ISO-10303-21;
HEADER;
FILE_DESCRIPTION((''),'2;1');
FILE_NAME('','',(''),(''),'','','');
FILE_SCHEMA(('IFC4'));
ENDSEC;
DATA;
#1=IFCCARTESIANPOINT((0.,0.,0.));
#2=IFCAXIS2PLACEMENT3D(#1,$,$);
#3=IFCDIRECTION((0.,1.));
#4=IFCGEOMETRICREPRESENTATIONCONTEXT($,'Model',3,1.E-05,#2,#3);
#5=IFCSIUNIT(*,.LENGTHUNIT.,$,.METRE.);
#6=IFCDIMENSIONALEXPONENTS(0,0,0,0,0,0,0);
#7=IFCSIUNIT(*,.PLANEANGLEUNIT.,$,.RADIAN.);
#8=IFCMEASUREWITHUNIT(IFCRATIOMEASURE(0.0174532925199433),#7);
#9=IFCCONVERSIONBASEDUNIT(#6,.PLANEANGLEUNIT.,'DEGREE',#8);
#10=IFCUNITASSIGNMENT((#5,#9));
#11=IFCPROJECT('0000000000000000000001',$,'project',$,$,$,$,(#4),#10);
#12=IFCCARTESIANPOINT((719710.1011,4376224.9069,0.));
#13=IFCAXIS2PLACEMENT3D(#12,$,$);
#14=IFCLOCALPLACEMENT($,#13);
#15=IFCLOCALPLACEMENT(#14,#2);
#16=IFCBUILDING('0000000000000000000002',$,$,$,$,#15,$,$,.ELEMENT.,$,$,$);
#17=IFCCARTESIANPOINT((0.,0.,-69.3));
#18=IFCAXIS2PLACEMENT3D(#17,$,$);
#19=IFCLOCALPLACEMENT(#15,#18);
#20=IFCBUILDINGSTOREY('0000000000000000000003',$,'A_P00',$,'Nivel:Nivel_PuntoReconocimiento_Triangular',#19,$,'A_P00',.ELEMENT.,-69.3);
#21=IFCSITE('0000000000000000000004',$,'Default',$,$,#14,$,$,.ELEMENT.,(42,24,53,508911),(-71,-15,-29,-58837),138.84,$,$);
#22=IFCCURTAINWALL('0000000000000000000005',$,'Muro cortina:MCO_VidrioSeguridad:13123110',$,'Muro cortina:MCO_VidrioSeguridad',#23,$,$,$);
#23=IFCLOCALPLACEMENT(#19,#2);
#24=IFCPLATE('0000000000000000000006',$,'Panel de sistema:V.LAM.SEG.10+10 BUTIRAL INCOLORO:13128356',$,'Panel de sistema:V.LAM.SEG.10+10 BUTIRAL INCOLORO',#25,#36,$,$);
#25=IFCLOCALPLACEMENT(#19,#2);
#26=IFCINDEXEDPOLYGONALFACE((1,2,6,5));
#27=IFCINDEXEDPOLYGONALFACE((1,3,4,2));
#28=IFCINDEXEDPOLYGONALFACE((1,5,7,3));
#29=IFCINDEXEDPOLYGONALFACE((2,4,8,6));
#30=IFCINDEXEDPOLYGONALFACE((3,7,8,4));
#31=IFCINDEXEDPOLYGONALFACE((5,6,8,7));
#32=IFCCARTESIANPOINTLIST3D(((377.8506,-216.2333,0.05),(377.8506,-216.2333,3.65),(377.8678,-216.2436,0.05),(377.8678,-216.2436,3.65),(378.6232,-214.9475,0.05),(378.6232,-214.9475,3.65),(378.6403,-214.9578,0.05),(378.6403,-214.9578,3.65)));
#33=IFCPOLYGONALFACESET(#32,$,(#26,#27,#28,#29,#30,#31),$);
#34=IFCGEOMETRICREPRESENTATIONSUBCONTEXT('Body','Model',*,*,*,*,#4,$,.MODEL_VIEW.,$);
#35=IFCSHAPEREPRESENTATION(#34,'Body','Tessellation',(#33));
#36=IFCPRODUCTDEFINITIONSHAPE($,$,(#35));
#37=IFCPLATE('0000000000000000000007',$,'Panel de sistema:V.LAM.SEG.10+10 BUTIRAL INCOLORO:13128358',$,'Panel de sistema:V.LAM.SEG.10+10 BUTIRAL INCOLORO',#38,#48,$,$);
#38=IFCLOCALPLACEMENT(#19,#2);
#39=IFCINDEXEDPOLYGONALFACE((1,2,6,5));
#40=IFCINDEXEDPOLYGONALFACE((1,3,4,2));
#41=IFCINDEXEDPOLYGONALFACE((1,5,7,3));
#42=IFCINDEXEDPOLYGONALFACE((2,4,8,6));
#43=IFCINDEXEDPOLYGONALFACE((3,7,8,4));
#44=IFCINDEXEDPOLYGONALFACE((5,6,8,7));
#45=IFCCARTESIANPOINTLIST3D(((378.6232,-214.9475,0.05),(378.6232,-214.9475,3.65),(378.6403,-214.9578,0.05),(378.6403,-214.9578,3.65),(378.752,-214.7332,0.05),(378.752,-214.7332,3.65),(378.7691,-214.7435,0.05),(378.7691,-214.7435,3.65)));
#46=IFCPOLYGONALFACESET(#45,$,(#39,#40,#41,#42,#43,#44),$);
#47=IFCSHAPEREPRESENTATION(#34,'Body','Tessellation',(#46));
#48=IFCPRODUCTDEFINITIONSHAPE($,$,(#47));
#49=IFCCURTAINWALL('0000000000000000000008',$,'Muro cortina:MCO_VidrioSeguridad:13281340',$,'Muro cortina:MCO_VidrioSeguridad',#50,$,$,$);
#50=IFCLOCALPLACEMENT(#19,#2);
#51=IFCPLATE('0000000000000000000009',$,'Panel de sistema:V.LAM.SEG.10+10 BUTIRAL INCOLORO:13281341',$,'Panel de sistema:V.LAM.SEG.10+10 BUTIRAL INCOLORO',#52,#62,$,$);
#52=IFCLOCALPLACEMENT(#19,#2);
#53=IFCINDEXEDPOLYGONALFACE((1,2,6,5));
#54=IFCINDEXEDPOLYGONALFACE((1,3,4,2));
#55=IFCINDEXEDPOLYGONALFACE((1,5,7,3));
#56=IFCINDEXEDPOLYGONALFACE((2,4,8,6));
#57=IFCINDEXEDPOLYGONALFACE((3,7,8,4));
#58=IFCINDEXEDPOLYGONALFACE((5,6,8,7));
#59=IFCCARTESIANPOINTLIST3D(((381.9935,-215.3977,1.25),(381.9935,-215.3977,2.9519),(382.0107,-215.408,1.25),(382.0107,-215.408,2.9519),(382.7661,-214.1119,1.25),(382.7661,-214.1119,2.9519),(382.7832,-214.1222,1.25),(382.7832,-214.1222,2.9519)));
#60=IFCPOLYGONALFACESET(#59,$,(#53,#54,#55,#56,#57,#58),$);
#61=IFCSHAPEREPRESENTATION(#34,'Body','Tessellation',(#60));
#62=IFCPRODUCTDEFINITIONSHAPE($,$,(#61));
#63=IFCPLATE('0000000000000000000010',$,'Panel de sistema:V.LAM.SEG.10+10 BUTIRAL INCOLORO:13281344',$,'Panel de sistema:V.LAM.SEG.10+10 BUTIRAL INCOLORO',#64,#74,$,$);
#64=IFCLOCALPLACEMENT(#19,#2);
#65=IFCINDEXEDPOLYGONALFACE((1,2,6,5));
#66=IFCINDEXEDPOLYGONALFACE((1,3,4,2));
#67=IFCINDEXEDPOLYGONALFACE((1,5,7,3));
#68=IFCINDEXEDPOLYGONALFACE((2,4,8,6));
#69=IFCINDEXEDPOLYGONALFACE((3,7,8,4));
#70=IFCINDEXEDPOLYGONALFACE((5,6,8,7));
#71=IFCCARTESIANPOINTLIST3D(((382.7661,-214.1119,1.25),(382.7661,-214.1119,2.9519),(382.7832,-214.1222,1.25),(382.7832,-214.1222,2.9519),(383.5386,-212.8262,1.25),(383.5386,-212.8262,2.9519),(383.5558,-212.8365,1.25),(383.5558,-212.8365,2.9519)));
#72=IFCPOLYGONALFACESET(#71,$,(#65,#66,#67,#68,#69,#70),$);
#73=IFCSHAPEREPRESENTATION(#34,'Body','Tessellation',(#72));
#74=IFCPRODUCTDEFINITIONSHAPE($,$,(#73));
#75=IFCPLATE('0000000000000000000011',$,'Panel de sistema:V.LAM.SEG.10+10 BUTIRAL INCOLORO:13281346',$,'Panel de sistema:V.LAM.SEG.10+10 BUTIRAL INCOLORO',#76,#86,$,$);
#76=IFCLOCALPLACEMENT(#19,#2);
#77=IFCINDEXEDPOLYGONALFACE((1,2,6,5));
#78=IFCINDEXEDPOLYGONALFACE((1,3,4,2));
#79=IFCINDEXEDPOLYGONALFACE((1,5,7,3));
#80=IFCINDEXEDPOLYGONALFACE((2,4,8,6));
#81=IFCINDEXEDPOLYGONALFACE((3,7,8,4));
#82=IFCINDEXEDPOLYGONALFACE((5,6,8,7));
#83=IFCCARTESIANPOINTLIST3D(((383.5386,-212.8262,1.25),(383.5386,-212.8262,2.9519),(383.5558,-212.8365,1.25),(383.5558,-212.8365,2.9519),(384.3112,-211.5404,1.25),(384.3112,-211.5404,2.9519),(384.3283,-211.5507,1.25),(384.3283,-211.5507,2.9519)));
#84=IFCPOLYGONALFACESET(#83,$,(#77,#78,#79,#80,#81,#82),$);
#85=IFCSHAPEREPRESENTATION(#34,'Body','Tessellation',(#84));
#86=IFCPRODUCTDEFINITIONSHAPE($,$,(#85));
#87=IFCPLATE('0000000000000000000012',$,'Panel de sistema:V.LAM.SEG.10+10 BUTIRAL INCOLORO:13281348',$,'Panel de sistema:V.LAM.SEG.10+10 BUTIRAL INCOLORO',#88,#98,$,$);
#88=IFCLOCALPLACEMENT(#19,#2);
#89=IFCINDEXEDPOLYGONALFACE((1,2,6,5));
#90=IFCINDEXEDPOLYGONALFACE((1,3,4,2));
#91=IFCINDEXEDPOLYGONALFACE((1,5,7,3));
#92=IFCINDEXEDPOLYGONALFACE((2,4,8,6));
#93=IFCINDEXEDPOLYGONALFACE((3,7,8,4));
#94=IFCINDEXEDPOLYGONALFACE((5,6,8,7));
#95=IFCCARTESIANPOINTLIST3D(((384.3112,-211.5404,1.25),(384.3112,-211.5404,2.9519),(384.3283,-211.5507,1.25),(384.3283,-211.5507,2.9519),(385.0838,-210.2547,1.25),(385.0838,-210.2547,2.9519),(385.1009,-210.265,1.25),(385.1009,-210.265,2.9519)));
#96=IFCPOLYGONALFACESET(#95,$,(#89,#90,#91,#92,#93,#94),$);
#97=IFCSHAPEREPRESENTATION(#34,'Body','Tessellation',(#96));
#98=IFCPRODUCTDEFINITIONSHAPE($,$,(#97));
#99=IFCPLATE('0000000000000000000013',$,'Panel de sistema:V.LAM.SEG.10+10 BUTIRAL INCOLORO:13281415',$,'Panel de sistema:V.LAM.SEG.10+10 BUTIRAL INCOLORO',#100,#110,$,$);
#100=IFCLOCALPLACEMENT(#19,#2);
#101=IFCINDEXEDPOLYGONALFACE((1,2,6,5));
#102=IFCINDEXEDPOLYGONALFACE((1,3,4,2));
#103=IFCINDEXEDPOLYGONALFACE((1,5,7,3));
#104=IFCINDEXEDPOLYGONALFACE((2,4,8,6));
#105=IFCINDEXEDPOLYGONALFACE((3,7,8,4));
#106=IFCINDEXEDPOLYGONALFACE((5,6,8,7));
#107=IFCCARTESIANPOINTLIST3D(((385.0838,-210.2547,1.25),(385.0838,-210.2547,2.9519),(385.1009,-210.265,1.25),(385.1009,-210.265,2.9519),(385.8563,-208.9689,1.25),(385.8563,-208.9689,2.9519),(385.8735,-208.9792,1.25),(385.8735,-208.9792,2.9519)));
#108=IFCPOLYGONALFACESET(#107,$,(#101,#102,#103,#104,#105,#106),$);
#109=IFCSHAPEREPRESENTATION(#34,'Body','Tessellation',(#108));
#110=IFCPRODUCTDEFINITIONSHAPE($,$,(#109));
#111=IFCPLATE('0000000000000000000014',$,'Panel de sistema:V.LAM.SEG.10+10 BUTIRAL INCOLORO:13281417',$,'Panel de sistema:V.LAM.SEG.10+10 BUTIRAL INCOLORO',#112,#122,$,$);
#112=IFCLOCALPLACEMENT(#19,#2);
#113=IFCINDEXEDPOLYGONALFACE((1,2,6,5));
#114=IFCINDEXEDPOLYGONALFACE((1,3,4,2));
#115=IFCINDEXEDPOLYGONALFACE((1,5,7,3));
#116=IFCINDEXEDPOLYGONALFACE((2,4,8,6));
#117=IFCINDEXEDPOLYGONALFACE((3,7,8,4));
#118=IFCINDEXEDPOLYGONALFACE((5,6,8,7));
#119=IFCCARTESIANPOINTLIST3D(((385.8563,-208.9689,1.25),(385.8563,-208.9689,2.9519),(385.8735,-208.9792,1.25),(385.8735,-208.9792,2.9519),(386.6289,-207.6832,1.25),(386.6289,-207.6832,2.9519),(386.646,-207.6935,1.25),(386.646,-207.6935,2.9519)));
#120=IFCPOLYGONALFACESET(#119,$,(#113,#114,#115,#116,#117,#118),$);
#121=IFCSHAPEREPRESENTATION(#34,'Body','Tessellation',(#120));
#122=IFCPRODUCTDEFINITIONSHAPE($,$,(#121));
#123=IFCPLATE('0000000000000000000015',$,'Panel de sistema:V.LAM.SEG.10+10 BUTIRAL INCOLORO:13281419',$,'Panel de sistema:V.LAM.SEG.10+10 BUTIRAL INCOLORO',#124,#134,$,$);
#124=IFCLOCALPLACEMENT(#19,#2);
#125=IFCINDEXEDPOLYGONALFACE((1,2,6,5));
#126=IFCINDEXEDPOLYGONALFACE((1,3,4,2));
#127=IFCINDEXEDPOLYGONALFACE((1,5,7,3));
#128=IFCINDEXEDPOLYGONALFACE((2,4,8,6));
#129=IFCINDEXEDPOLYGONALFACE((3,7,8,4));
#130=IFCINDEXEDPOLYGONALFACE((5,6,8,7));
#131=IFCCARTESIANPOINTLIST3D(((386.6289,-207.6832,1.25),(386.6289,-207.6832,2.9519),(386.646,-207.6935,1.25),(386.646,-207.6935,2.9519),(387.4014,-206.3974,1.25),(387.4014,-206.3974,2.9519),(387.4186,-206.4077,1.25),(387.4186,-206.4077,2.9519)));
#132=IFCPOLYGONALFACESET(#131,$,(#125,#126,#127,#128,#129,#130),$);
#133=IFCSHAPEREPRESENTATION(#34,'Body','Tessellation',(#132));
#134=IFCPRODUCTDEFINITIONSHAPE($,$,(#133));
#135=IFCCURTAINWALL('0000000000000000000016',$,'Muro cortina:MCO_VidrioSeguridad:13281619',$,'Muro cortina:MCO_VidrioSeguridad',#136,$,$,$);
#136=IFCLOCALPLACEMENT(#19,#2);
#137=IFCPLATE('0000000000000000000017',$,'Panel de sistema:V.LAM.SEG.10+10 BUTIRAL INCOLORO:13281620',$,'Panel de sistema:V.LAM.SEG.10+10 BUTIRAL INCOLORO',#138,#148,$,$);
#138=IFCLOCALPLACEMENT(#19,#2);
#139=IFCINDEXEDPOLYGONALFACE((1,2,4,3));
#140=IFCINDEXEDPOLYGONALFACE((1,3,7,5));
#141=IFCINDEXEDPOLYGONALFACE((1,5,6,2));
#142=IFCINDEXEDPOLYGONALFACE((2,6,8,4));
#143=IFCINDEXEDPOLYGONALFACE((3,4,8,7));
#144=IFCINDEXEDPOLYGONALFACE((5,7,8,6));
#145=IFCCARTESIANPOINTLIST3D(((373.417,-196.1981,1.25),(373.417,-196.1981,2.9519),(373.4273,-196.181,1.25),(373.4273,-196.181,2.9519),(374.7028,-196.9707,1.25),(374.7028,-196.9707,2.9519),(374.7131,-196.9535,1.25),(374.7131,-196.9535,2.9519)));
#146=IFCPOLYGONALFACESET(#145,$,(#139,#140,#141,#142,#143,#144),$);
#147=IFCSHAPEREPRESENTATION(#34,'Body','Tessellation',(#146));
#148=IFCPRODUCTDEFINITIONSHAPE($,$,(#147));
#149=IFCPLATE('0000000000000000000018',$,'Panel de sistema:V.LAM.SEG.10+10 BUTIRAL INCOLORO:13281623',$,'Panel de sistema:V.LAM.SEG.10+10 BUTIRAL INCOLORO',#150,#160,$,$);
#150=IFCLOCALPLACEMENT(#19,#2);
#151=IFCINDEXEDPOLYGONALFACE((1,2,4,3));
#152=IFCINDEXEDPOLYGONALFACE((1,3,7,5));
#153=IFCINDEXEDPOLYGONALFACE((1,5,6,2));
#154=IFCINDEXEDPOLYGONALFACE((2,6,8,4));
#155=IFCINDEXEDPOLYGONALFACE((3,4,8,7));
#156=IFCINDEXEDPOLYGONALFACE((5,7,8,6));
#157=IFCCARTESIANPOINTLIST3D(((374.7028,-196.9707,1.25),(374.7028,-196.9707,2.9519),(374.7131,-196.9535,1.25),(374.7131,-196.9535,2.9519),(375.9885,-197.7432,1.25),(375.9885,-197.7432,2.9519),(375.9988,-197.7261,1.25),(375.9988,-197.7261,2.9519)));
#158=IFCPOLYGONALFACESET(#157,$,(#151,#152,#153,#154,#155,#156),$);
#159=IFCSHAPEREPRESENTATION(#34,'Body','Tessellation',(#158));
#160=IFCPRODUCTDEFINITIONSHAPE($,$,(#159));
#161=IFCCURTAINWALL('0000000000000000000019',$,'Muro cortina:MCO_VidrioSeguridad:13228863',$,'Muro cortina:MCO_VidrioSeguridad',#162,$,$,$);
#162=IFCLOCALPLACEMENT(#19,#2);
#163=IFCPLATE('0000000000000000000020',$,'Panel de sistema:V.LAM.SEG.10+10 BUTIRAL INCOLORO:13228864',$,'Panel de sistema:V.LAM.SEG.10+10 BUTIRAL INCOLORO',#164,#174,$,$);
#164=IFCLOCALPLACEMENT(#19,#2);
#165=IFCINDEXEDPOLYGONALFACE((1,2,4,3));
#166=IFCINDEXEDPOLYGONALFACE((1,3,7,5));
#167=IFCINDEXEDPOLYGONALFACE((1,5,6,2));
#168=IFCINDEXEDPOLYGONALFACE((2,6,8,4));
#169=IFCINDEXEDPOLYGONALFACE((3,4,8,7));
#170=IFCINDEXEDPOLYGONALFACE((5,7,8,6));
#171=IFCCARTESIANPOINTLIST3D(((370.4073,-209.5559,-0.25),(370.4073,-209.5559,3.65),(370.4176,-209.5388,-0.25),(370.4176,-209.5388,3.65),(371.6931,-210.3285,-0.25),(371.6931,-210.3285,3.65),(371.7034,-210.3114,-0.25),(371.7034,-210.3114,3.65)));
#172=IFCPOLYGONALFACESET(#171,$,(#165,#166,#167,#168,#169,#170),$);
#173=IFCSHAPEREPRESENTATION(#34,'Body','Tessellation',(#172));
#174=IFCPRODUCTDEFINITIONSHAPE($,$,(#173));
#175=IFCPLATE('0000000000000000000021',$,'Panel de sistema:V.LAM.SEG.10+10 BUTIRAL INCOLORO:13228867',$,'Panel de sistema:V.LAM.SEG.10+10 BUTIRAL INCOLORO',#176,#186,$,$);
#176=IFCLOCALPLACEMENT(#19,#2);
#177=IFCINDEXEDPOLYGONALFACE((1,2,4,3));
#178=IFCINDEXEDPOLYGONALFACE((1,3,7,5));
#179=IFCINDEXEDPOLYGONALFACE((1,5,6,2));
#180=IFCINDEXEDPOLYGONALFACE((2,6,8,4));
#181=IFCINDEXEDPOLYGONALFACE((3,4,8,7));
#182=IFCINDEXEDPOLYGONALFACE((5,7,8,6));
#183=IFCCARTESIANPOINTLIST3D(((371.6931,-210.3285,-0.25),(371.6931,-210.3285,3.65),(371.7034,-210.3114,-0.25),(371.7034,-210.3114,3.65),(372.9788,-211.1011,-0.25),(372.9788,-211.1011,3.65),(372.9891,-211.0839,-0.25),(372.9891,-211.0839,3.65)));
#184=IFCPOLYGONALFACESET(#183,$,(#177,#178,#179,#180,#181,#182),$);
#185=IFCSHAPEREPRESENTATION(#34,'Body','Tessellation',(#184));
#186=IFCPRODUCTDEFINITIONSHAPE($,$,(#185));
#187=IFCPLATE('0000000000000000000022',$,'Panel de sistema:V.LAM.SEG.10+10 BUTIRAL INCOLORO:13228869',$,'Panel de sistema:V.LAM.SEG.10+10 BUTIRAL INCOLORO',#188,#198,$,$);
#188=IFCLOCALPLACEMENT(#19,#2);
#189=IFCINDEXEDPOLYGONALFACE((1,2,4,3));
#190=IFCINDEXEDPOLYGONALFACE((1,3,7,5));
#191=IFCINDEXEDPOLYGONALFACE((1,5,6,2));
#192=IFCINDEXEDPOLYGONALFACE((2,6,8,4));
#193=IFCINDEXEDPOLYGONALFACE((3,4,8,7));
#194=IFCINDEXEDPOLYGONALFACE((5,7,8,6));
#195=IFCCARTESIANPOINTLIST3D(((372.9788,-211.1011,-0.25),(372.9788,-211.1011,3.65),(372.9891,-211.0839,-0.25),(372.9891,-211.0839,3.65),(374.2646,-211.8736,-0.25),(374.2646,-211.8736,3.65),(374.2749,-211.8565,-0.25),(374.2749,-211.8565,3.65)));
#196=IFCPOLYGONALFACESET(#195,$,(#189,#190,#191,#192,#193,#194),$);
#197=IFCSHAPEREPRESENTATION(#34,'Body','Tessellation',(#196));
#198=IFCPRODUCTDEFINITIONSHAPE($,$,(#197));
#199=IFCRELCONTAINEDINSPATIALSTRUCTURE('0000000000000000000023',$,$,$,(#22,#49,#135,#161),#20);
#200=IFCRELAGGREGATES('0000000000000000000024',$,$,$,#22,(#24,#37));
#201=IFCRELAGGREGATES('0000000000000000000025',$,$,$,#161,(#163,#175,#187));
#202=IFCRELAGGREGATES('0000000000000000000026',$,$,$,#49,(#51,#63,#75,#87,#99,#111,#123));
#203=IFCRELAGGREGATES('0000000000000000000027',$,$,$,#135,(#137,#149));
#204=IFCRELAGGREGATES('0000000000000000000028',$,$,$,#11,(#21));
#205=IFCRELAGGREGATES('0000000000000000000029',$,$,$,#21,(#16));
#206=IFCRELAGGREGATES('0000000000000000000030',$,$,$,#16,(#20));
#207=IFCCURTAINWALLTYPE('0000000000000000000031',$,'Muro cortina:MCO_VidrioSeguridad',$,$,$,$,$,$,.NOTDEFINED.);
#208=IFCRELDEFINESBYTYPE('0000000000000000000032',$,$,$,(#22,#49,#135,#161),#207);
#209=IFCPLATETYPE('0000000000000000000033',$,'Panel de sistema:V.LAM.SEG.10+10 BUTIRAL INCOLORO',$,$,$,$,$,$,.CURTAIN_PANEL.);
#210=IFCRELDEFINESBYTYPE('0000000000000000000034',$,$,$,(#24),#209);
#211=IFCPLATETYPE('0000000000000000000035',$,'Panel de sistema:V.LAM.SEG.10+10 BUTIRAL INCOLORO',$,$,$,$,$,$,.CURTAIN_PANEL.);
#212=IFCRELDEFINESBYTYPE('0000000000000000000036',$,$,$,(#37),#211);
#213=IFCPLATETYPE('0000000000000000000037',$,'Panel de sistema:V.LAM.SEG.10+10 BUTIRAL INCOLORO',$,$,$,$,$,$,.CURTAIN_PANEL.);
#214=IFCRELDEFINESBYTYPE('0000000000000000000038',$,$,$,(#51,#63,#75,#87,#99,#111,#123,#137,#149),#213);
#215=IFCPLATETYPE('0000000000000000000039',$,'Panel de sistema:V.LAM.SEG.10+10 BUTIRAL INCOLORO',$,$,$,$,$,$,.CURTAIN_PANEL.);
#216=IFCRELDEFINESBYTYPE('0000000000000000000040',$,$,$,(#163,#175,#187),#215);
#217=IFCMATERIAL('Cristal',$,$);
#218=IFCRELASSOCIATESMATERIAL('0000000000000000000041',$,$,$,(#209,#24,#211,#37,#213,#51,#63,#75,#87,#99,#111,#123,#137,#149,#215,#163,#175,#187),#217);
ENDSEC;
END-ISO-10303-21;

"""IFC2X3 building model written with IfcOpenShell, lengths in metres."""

from ifc_helpers import new_model, entity, si_unit, converted_unit, direction, frame, frame_2d, origin, origin_2d_with_axis, place, context, subcontext, project, spatial, rectangle, extrude, source, transform, mapped, material, type_object, type_shapes, element, aggregate, save


model = new_model("IFC2X3")

# Units and contexts
model_context = context("Model", 3, precision=1e-05, world=origin(), true_north=direction((0.0, 1.0)))
body_context = subcontext(model_context, "Body", "Model", "MODEL_VIEW")
ifc_project = project(units=[si_unit("LENGTHUNIT", "METRE"), converted_unit("PLANEANGLEUNIT", "DEGREE", entity("IfcRatioMeasure", 0.0174532925199433), si_unit("PLANEANGLEUNIT", "RADIAN"), dimensions=[0, 0, 0, 0, 0, 0, 0])], contexts=[model_context])

# Site, building, storey
site_placement = place(None, frame((719710.1011, 4376224.9069, 0.0)))
site = spatial("IfcSite", under=ifc_project, at=site_placement, Name="Default", CompositionType="ELEMENT", RefLatitude=(42, 24, 53, 508911), RefLongitude=(-71, -15, -29, -58837), RefElevation=138.84)
building_placement = place(site_placement, origin())
building = spatial("IfcBuilding", under=site, at=building_placement, CompositionType="ELEMENT")
storey_placement = place(building_placement, frame((0.0, 0.0, -69.3)))
storey = spatial("IfcBuildingStorey", under=building, at=storey_placement, Name="A_P00", ObjectType="Nivel:Nivel_PuntoReconocimiento_Triangular", LongName="A_P00", CompositionType="ELEMENT", Elevation=-69.3)

# Curtain walls, plates
curtain_wall_type = type_object("IfcCurtainWallType", Name="Muro cortina:MCO_VidrioSeguridad", PredefinedType="NOTDEFINED")
curtain_wall_1_placement = place(storey_placement, frame((0.0, 0.0, 69.3)))
curtain_wall_1 = element("IfcCurtainWall", 1, at=curtain_wall_1_placement, inside=storey, type_object=curtain_wall_type, Name="Muro cortina:MCO_VidrioSeguridad:13123110", ObjectType="Muro cortina:MCO_VidrioSeguridad")
ifc_material_1 = material(Name="Cristal")
plate_type_1 = type_object("IfcPlateType", Name="Panel de sistema:V.LAM.SEG.10+10 BUTIRAL INCOLORO", PredefinedType="CURTAIN_PANEL", material=ifc_material_1)
shared_shape_1 = source(origin(), body_context, "Body", "SweptSolid", [
    extrude(rectangle(XDim=0.02, YDim=1.5, at=frame_2d((0.0, 0.0), x_axis=(1.0, 0.0))), frame((0.0, 0.0, 0.0), z_axis=(0.0, 0.0, 1.0), x_axis=(0.0, 1.0, 0.0)), (0.0, 0.0, 1.0), 3.6),
])
type_shapes(plate_type_1, [shared_shape_1])
plate_1_placement = place(curtain_wall_1_placement, frame((378.2455, -215.5955, -69.25), z_axis=(0.0, 0.0, 1.0), x_axis=(0.515038, 0.857167, 0.0)))
plate_1 = element("IfcPlate", 2, at=plate_1_placement, type_object=plate_type_1, material=ifc_material_1, Name="Panel de sistema:V.LAM.SEG.10+10 BUTIRAL INCOLORO:13128356", ObjectType="Panel de sistema:V.LAM.SEG.10+10 BUTIRAL INCOLORO", context=body_context, shape_type="MappedRepresentation", body=[
    mapped(shared_shape_1, transform((0.0, 0.0, 0.0), scale=1.0)),
])
plate_type_2 = type_object("IfcPlateType", Name="Panel de sistema:V.LAM.SEG.10+10 BUTIRAL INCOLORO", PredefinedType="CURTAIN_PANEL", material=ifc_material_1)
shared_shape_2 = source(origin(), body_context, "Body", "SweptSolid", [
    extrude(rectangle(XDim=0.02, YDim=0.25, at=origin_2d_with_axis()), frame((0.0, 0.0, 0.0), z_axis=(0.0, 0.0, 1.0), x_axis=(0.0, 1.0, 0.0)), (0.0, 0.0, 1.0), 3.6),
])
type_shapes(plate_type_2, [shared_shape_2])
plate_2_placement = place(curtain_wall_1_placement, frame((378.6962, -214.8455, -69.25), z_axis=(0.0, 0.0, 1.0), x_axis=(0.515038, 0.857167, 0.0)))
plate_2 = element("IfcPlate", 3, at=plate_2_placement, type_object=plate_type_2, material=ifc_material_1, Name="Panel de sistema:V.LAM.SEG.10+10 BUTIRAL INCOLORO:13128358", ObjectType="Panel de sistema:V.LAM.SEG.10+10 BUTIRAL INCOLORO", context=body_context, shape_type="MappedRepresentation", body=[
    mapped(shared_shape_2, transform((0.0, 0.0, 0.0), scale=1.0)),
])
aggregate(curtain_wall_1, [plate_1, plate_2])
curtain_wall_2_placement = place(storey_placement, frame((0.0, 0.0, 69.3)))
curtain_wall_2 = element("IfcCurtainWall", 4, at=curtain_wall_2_placement, inside=storey, type_object=curtain_wall_type, Name="Muro cortina:MCO_VidrioSeguridad:13281340", ObjectType="Muro cortina:MCO_VidrioSeguridad")
plate_type_3 = type_object("IfcPlateType", Name="Panel de sistema:V.LAM.SEG.10+10 BUTIRAL INCOLORO", PredefinedType="CURTAIN_PANEL", material=ifc_material_1)
shared_shape_3 = source(origin(), body_context, "Body", "SweptSolid", [
    extrude(rectangle(XDim=0.02, YDim=1.5, at=frame_2d((0.0, 0.0), x_axis=(1.0, 0.0))), frame((0.0, 0.0, 0.0), z_axis=(0.0, 0.0, 1.0), x_axis=(0.0, 1.0, 0.0)), (0.0, 0.0, 1.0), 1.7019),
])
type_shapes(plate_type_3, [shared_shape_3])
plate_3_placement = place(curtain_wall_2_placement, frame((382.3884, -214.7599, -68.05), z_axis=(0.0, 0.0, 1.0), x_axis=(0.515038, 0.857167, 0.0)))
plate_3 = element("IfcPlate", 5, at=plate_3_placement, type_object=plate_type_3, material=ifc_material_1, Name="Panel de sistema:V.LAM.SEG.10+10 BUTIRAL INCOLORO:13281341", ObjectType="Panel de sistema:V.LAM.SEG.10+10 BUTIRAL INCOLORO", context=body_context, shape_type="MappedRepresentation", body=[
    mapped(shared_shape_3, transform((0.0, 0.0, 0.0), scale=1.0)),
])
plate_4_placement = place(curtain_wall_2_placement, frame((383.1609, -213.4742, -68.05), z_axis=(0.0, 0.0, 1.0), x_axis=(0.515038, 0.857167, 0.0)))
plate_4 = element("IfcPlate", 6, at=plate_4_placement, type_object=plate_type_3, material=ifc_material_1, Name="Panel de sistema:V.LAM.SEG.10+10 BUTIRAL INCOLORO:13281344", ObjectType="Panel de sistema:V.LAM.SEG.10+10 BUTIRAL INCOLORO", context=body_context, shape_type="MappedRepresentation", body=[
    mapped(shared_shape_3, transform((0.0, 0.0, 0.0), scale=1.0)),
])
plate_5_placement = place(curtain_wall_2_placement, frame((383.9335, -212.1884, -68.05), z_axis=(0.0, 0.0, 1.0), x_axis=(0.515038, 0.857167, 0.0)))
plate_5 = element("IfcPlate", 7, at=plate_5_placement, type_object=plate_type_3, material=ifc_material_1, Name="Panel de sistema:V.LAM.SEG.10+10 BUTIRAL INCOLORO:13281346", ObjectType="Panel de sistema:V.LAM.SEG.10+10 BUTIRAL INCOLORO", context=body_context, shape_type="MappedRepresentation", body=[
    mapped(shared_shape_3, transform((0.0, 0.0, 0.0), scale=1.0)),
])
plate_6_placement = place(curtain_wall_2_placement, frame((384.706, -210.9027, -68.05), z_axis=(0.0, 0.0, 1.0), x_axis=(0.515038, 0.857167, 0.0)))
plate_6 = element("IfcPlate", 8, at=plate_6_placement, type_object=plate_type_3, material=ifc_material_1, Name="Panel de sistema:V.LAM.SEG.10+10 BUTIRAL INCOLORO:13281348", ObjectType="Panel de sistema:V.LAM.SEG.10+10 BUTIRAL INCOLORO", context=body_context, shape_type="MappedRepresentation", body=[
    mapped(shared_shape_3, transform((0.0, 0.0, 0.0), scale=1.0)),
])
plate_7_placement = place(curtain_wall_2_placement, frame((385.4786, -209.6169, -68.05), z_axis=(0.0, 0.0, 1.0), x_axis=(0.515038, 0.857167, 0.0)))
plate_7 = element("IfcPlate", 9, at=plate_7_placement, type_object=plate_type_3, material=ifc_material_1, Name="Panel de sistema:V.LAM.SEG.10+10 BUTIRAL INCOLORO:13281415", ObjectType="Panel de sistema:V.LAM.SEG.10+10 BUTIRAL INCOLORO", context=body_context, shape_type="MappedRepresentation", body=[
    mapped(shared_shape_3, transform((0.0, 0.0, 0.0), scale=1.0)),
])
plate_8_placement = place(curtain_wall_2_placement, frame((386.2512, -208.3312, -68.05), z_axis=(0.0, 0.0, 1.0), x_axis=(0.515038, 0.857167, 0.0)))
plate_8 = element("IfcPlate", 10, at=plate_8_placement, type_object=plate_type_3, material=ifc_material_1, Name="Panel de sistema:V.LAM.SEG.10+10 BUTIRAL INCOLORO:13281417", ObjectType="Panel de sistema:V.LAM.SEG.10+10 BUTIRAL INCOLORO", context=body_context, shape_type="MappedRepresentation", body=[
    mapped(shared_shape_3, transform((0.0, 0.0, 0.0), scale=1.0)),
])
plate_9_placement = place(curtain_wall_2_placement, frame((387.0237, -207.0454, -68.05), z_axis=(0.0, 0.0, 1.0), x_axis=(0.515038, 0.857167, 0.0)))
plate_9 = element("IfcPlate", 11, at=plate_9_placement, type_object=plate_type_3, material=ifc_material_1, Name="Panel de sistema:V.LAM.SEG.10+10 BUTIRAL INCOLORO:13281419", ObjectType="Panel de sistema:V.LAM.SEG.10+10 BUTIRAL INCOLORO", context=body_context, shape_type="MappedRepresentation", body=[
    mapped(shared_shape_3, transform((0.0, 0.0, 0.0), scale=1.0)),
])
curtain_wall_3_placement = place(storey_placement, frame((0.0, 0.0, 69.3)))
curtain_wall_3 = element("IfcCurtainWall", 12, at=curtain_wall_3_placement, inside=storey, type_object=curtain_wall_type, Name="Muro cortina:MCO_VidrioSeguridad:13281619", ObjectType="Muro cortina:MCO_VidrioSeguridad")
plate_10_placement = place(curtain_wall_3_placement, frame((374.065, -196.5758, -68.05), z_axis=(0.0, 0.0, 1.0), x_axis=(0.857167, -0.515038, 0.0)))
plate_10 = element("IfcPlate", 13, at=plate_10_placement, type_object=plate_type_3, material=ifc_material_1, Name="Panel de sistema:V.LAM.SEG.10+10 BUTIRAL INCOLORO:13281620", ObjectType="Panel de sistema:V.LAM.SEG.10+10 BUTIRAL INCOLORO", context=body_context, shape_type="MappedRepresentation", body=[
    mapped(shared_shape_3, transform((0.0, 0.0, 0.0), scale=1.0)),
])
plate_11_placement = place(curtain_wall_3_placement, frame((375.3508, -197.3484, -68.05), z_axis=(0.0, 0.0, 1.0), x_axis=(0.857167, -0.515038, 0.0)))
plate_11 = element("IfcPlate", 14, at=plate_11_placement, type_object=plate_type_3, material=ifc_material_1, Name="Panel de sistema:V.LAM.SEG.10+10 BUTIRAL INCOLORO:13281623", ObjectType="Panel de sistema:V.LAM.SEG.10+10 BUTIRAL INCOLORO", context=body_context, shape_type="MappedRepresentation", body=[
    mapped(shared_shape_3, transform((0.0, 0.0, 0.0), scale=1.0)),
])
curtain_wall_4_placement = place(storey_placement, frame((0.0, 0.0, 69.3)))
curtain_wall_4 = element("IfcCurtainWall", 15, at=curtain_wall_4_placement, inside=storey, type_object=curtain_wall_type, Name="Muro cortina:MCO_VidrioSeguridad:13228863", ObjectType="Muro cortina:MCO_VidrioSeguridad")
plate_type_4 = type_object("IfcPlateType", Name="Panel de sistema:V.LAM.SEG.10+10 BUTIRAL INCOLORO", PredefinedType="CURTAIN_PANEL", material=ifc_material_1)
shared_shape_4 = source(origin(), body_context, "Body", "SweptSolid", [
    extrude(rectangle(XDim=0.02, YDim=1.5, at=origin_2d_with_axis()), frame((0.0, 0.0, 0.0), z_axis=(0.0, 0.0, 1.0), x_axis=(0.0, 1.0, 0.0)), (0.0, 0.0, 1.0), 3.9),
])
type_shapes(plate_type_4, [shared_shape_4])
plate_12_placement = place(curtain_wall_4_placement, frame((371.0554, -209.9337, -69.55), z_axis=(0.0, 0.0, 1.0), x_axis=(0.857167, -0.515038, 0.0)))
plate_12 = element("IfcPlate", 16, at=plate_12_placement, type_object=plate_type_4, material=ifc_material_1, Name="Panel de sistema:V.LAM.SEG.10+10 BUTIRAL INCOLORO:13228864", ObjectType="Panel de sistema:V.LAM.SEG.10+10 BUTIRAL INCOLORO", context=body_context, shape_type="MappedRepresentation", body=[
    mapped(shared_shape_4, transform((0.0, 0.0, 0.0), scale=1.0)),
])
plate_13_placement = place(curtain_wall_4_placement, frame((372.3411, -210.7062, -69.55), z_axis=(0.0, 0.0, 1.0), x_axis=(0.857167, -0.515038, 0.0)))
plate_13 = element("IfcPlate", 17, at=plate_13_placement, type_object=plate_type_4, material=ifc_material_1, Name="Panel de sistema:V.LAM.SEG.10+10 BUTIRAL INCOLORO:13228867", ObjectType="Panel de sistema:V.LAM.SEG.10+10 BUTIRAL INCOLORO", context=body_context, shape_type="MappedRepresentation", body=[
    mapped(shared_shape_4, transform((0.0, 0.0, 0.0), scale=1.0)),
])
plate_14_placement = place(curtain_wall_4_placement, frame((373.6269, -211.4788, -69.55), z_axis=(0.0, 0.0, 1.0), x_axis=(0.857167, -0.515038, 0.0)))
plate_14 = element("IfcPlate", 18, at=plate_14_placement, type_object=plate_type_4, material=ifc_material_1, Name="Panel de sistema:V.LAM.SEG.10+10 BUTIRAL INCOLORO:13228869", ObjectType="Panel de sistema:V.LAM.SEG.10+10 BUTIRAL INCOLORO", context=body_context, shape_type="MappedRepresentation", body=[
    mapped(shared_shape_4, transform((0.0, 0.0, 0.0), scale=1.0)),
])

aggregate(curtain_wall_4, [plate_12, plate_13, plate_14])
aggregate(curtain_wall_2, [plate_3, plate_4, plate_5, plate_6, plate_7, plate_8, plate_9])
aggregate(curtain_wall_3, [plate_10, plate_11])

save(model, "model.ifc")
